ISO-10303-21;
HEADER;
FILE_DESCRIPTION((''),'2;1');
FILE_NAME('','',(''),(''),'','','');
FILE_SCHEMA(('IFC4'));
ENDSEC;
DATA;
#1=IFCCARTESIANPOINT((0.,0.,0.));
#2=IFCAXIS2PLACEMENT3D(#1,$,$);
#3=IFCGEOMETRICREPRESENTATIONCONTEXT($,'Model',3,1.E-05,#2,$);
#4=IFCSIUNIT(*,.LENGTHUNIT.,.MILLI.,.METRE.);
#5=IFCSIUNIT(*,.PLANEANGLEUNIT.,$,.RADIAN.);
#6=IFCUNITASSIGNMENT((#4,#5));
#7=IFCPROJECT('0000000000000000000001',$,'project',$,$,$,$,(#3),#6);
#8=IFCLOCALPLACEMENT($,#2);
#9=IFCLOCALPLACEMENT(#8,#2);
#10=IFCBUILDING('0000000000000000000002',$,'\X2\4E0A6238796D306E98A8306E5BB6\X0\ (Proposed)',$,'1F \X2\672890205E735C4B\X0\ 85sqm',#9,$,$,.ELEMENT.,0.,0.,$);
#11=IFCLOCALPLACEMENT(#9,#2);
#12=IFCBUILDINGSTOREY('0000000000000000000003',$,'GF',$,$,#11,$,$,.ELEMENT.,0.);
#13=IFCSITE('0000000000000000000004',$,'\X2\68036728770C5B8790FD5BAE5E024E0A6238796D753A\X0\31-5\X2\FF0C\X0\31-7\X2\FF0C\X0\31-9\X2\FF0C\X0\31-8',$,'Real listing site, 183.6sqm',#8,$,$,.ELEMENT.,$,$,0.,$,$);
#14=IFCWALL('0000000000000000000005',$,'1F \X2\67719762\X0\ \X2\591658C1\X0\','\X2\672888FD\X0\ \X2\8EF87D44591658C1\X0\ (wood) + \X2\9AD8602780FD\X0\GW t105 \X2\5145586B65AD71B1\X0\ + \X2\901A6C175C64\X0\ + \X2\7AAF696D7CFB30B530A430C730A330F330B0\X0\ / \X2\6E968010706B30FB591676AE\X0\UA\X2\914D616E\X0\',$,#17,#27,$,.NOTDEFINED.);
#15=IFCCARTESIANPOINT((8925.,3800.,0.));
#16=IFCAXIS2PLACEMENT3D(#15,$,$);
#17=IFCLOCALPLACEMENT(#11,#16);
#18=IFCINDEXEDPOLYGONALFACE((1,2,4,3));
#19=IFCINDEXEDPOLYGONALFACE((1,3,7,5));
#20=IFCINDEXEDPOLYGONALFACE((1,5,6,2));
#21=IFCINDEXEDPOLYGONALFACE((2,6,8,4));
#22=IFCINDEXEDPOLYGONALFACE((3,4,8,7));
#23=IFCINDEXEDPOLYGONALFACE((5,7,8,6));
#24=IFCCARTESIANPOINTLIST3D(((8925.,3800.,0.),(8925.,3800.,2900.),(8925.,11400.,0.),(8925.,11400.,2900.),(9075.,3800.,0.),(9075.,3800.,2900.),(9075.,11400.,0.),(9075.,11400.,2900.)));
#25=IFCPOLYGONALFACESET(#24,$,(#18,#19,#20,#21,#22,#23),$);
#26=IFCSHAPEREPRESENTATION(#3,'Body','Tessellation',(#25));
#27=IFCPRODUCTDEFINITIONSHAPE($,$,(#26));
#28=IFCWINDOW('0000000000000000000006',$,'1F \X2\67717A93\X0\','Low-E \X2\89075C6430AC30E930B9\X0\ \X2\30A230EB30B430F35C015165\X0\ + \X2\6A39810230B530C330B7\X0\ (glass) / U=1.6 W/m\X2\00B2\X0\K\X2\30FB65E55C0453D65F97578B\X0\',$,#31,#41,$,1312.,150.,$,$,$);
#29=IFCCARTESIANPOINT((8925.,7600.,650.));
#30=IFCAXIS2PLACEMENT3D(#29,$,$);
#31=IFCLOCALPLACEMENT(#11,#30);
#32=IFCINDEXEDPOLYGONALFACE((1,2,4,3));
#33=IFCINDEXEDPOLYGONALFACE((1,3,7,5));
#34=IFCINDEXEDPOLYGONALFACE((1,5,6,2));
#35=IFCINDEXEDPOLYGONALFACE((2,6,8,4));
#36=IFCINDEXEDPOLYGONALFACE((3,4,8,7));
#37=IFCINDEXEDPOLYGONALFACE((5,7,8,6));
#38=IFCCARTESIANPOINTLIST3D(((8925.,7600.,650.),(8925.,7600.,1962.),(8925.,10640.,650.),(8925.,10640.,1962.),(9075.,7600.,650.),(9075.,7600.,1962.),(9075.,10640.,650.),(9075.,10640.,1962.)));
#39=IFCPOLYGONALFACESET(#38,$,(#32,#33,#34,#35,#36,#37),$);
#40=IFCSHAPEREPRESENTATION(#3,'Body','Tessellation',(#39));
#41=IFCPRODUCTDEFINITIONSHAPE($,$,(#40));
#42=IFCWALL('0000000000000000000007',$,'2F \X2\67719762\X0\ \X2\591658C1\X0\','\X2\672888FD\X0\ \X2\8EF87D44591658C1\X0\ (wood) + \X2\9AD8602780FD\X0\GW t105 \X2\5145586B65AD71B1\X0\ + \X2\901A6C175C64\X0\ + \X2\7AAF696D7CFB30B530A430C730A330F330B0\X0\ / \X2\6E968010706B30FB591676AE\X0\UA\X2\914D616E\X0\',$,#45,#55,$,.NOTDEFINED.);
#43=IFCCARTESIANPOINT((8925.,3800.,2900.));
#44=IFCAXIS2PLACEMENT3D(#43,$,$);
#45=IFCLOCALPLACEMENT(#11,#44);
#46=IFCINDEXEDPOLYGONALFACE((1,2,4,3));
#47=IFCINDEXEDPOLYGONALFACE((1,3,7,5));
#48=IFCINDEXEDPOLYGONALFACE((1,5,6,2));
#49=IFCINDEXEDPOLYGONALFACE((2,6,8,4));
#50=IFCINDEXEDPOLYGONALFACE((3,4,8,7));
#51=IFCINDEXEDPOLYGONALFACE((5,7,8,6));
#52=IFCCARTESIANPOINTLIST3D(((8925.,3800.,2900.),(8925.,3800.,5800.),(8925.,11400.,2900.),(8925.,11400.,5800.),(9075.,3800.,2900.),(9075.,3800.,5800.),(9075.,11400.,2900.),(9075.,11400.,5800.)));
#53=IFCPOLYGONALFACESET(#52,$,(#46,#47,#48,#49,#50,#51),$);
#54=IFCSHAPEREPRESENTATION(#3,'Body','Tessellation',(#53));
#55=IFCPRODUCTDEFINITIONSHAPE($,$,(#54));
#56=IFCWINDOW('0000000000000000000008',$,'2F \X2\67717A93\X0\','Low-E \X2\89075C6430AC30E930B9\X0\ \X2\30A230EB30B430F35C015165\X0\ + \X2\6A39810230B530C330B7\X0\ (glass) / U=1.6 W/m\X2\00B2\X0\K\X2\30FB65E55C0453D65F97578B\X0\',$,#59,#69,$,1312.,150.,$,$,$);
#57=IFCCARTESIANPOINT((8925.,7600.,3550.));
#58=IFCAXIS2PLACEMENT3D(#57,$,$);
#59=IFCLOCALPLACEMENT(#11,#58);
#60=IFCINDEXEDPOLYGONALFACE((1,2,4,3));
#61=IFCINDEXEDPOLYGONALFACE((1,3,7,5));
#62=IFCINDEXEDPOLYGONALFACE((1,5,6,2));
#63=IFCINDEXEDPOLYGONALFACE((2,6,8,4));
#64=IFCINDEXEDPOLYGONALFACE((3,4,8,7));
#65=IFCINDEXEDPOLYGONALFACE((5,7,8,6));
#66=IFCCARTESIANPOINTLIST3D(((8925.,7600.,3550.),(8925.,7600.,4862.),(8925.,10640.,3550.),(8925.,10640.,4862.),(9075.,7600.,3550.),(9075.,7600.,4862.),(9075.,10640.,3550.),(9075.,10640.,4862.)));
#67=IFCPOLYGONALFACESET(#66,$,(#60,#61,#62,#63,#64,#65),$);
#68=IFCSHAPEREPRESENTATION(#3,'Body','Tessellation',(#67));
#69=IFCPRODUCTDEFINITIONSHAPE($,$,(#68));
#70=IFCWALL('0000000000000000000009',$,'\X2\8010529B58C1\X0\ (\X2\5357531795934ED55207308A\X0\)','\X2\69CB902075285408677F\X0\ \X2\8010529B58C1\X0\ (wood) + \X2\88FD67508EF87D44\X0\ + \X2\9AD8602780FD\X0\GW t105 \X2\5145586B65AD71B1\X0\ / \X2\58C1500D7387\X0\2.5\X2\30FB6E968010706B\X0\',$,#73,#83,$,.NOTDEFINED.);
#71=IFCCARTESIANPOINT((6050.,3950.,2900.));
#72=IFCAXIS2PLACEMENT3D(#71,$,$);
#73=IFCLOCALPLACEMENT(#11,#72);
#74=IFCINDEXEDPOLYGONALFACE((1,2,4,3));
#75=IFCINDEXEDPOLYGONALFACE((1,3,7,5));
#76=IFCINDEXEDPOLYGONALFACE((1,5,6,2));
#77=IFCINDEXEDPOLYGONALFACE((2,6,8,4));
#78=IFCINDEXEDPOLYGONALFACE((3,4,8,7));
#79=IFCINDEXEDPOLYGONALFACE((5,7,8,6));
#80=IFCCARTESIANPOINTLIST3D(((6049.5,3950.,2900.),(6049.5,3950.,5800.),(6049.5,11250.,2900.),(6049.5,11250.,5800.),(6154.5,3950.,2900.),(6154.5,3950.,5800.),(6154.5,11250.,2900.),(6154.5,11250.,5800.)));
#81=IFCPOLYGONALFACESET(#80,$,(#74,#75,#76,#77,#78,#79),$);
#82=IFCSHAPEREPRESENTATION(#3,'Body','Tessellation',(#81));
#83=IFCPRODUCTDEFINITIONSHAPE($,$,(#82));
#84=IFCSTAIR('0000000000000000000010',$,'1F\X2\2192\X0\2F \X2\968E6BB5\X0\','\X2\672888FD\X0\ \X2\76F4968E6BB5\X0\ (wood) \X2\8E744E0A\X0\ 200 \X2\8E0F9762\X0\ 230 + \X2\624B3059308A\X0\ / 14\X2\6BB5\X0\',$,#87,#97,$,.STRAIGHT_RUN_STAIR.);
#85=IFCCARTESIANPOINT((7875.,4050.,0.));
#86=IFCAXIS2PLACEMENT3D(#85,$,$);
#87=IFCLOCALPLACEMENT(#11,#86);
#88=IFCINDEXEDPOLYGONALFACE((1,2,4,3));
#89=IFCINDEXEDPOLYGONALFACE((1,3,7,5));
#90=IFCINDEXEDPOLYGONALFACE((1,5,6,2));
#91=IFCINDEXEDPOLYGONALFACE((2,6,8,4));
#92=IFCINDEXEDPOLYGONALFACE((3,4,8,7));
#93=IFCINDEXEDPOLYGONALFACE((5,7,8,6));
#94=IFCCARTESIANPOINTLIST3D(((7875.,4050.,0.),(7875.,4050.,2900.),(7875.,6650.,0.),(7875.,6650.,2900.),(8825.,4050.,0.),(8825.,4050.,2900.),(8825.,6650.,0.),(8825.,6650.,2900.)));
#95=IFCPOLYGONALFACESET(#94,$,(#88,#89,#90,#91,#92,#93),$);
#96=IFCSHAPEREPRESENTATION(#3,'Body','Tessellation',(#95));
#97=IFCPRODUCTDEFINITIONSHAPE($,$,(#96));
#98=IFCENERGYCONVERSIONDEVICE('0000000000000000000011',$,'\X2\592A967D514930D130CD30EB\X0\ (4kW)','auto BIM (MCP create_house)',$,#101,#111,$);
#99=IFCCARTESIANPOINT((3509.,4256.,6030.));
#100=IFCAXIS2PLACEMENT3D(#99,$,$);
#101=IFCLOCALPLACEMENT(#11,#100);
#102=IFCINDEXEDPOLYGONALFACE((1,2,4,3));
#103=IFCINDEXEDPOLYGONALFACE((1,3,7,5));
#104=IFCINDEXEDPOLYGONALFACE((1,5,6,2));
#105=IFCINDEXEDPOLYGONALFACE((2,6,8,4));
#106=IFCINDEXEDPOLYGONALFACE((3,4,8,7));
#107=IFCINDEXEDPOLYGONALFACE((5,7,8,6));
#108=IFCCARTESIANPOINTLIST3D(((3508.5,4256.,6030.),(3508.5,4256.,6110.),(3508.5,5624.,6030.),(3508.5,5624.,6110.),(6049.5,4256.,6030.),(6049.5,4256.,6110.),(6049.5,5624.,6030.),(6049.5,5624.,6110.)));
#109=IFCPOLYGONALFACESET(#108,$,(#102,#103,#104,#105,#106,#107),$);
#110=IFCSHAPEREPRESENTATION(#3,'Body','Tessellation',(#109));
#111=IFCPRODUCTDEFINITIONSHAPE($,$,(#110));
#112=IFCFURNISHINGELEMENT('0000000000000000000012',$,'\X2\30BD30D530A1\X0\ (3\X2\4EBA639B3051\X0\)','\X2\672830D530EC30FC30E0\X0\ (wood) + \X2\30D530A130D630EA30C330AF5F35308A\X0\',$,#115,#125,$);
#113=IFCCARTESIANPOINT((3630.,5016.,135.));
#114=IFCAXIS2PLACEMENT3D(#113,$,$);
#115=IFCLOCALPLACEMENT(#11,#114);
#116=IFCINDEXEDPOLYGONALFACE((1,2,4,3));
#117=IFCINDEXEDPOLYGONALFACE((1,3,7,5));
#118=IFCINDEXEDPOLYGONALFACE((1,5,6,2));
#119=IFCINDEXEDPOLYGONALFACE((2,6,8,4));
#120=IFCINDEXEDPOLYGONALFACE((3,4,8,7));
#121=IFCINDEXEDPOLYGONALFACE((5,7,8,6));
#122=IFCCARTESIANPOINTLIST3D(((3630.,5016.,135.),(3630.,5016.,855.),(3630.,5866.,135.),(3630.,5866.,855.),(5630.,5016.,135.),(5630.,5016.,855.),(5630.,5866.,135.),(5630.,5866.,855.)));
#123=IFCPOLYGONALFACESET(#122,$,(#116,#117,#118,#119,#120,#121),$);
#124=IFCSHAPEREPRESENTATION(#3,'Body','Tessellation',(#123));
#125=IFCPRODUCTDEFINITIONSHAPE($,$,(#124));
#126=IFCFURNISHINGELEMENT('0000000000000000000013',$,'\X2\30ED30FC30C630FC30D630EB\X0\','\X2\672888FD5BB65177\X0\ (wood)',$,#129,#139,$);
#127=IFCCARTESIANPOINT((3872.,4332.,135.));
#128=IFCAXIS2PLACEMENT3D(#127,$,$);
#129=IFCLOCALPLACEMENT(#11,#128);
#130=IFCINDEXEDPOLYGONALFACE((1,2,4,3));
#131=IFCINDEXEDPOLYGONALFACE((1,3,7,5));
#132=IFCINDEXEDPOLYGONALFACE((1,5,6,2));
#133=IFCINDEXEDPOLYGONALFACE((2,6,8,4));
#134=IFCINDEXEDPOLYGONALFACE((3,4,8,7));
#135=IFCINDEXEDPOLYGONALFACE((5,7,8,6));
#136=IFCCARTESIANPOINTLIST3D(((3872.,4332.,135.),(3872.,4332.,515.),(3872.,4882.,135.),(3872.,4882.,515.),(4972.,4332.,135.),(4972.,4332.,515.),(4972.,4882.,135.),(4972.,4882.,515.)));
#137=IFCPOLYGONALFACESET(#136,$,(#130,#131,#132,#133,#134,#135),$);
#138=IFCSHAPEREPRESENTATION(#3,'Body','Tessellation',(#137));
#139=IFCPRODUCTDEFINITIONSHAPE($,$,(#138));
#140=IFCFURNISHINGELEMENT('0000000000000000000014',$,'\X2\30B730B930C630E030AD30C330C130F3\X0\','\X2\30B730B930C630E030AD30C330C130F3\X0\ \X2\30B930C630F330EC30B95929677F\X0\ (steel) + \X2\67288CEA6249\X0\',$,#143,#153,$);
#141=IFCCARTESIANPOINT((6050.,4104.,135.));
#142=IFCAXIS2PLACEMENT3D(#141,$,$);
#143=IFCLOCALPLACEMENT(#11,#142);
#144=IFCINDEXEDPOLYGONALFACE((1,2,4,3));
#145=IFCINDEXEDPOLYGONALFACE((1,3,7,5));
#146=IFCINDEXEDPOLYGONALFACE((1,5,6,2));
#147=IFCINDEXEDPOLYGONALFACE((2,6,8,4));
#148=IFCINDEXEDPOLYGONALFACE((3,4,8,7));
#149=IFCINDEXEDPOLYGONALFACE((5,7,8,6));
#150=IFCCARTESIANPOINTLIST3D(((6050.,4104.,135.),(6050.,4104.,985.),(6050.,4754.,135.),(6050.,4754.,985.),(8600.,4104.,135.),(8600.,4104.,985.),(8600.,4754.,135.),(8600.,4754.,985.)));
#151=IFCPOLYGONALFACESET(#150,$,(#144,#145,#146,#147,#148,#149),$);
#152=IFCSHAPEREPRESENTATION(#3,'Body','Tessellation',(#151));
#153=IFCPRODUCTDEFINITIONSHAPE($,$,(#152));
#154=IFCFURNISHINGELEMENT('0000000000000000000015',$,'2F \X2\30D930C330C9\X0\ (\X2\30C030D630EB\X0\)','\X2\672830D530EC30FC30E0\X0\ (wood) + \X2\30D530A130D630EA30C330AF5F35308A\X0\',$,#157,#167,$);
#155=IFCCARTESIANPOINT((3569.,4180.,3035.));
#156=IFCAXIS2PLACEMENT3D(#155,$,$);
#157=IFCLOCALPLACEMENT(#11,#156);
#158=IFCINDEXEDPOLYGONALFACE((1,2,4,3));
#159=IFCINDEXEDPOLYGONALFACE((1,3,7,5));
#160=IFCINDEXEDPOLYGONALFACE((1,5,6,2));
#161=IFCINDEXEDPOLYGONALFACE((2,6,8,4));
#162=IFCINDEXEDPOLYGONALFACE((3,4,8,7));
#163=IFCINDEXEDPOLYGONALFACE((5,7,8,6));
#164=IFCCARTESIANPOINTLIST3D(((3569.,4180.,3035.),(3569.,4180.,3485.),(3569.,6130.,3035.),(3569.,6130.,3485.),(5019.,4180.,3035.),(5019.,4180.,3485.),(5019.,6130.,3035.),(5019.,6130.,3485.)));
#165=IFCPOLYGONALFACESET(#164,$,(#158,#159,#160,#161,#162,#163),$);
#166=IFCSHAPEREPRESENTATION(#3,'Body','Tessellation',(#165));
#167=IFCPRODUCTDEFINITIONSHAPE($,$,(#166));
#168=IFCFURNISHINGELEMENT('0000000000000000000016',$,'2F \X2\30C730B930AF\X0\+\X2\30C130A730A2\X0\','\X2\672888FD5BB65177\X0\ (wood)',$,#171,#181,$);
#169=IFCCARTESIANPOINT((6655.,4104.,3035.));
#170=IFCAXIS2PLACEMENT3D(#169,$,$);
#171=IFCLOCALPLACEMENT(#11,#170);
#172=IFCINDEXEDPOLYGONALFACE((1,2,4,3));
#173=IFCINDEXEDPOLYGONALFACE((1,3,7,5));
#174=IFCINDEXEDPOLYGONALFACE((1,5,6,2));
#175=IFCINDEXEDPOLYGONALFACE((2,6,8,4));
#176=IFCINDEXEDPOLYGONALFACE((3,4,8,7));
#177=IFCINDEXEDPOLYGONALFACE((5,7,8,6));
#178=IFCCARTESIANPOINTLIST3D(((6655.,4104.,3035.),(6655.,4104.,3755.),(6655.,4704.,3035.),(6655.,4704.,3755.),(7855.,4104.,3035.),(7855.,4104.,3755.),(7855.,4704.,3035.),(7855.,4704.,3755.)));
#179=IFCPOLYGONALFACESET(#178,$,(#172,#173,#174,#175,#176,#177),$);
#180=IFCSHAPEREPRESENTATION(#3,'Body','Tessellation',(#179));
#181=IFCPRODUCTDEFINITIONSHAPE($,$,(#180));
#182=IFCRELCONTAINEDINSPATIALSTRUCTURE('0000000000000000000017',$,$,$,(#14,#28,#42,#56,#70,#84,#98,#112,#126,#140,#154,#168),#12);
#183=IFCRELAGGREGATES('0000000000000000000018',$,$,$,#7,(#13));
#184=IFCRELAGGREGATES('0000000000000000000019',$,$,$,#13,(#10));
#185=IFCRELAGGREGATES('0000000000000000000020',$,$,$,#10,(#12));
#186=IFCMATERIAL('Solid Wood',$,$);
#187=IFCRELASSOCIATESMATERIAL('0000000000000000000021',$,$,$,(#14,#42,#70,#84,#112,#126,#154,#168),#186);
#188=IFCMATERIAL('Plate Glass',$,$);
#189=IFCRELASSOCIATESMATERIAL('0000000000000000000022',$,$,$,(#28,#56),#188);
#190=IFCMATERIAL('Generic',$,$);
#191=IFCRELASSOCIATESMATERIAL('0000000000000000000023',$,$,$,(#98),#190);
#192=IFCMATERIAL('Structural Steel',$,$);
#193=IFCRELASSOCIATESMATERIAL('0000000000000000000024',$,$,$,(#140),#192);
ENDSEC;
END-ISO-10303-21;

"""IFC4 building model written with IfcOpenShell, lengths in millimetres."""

from ifc_helpers import new_model, si_unit, frame, frame_2d, origin, place, context, project, spatial, rectangle, extrude, material, element, fill, save


model = new_model("IFC4")

# Units and contexts
model_context = context("Model", 3, precision=1e-05, world=origin())
ifc_project = project(units=[si_unit("LENGTHUNIT", "METRE", prefix="MILLI"), si_unit("PLANEANGLEUNIT", "RADIAN")], contexts=[model_context])

# Site, building, storey
site_placement = place(None, origin())
site = spatial("IfcSite", under=ifc_project, at=site_placement, Name="栃木県宇都宮市上戸祭町31-5，31-7，31-9，31-8", ObjectType="Real listing site, 183.6sqm", CompositionType="ELEMENT", RefElevation=0.0)
building_placement = place(site_placement, origin())
building = spatial("IfcBuilding", under=site, at=building_placement, Name="上戸祭の風の家 (Proposed)", ObjectType="1F 木造平屋 85sqm", CompositionType="ELEMENT", ElevationOfRefHeight=0.0, ElevationOfTerrain=0.0)
storey_placement = place(building_placement, origin())
storey = spatial("IfcBuildingStorey", under=building, at=storey_placement, Name="GF", CompositionType="ELEMENT", Elevation=0.0)

# Wall, opening, window
ifc_material_1 = material(Name="Solid Wood")
wall_1_placement = place(storey_placement, frame((8925.0, 3800.0, 0.0)))
wall_1 = element("IfcWall", 1, at=wall_1_placement, inside=storey, material=ifc_material_1, Name="1F 東面 外壁", Description="木製 軸組外壁 (wood) + 高性能GW t105 充填断熱 + 通気層 + 窯業系サイディング / 準耐火・外皮UA配慮", PredefinedType="NOTDEFINED", context=model_context, shape_type="SweptSolid", body=[
    extrude(rectangle(XDim=150.0, YDim=7600.0, at=frame_2d((75.0, 3800.0))), frame((8925.0, 3800.0, 0.0)), (0.0, 0.0, 1.0), 2900.0),
])
opening_1_placement = place(storey_placement, frame((8925.0, 7600.0, 650.0)))
opening_1 = element("IfcOpeningElement", 2, at=opening_1_placement, cuts=wall_1, PredefinedType="NOTDEFINED", context=model_context, shape_type="SweptSolid", body=[
    extrude(rectangle(XDim=150.0, YDim=3040.0, at=frame_2d((75.0, 1520.0))), frame((8925.0, 7600.0, 650.0)), (0.0, 0.0, 1.0), 1312.0),
])
ifc_material_2 = material(Name="Plate Glass")
window_1_placement = place(storey_placement, frame((8925.0, 7600.0, 650.0)))
window_1 = element("IfcWindow", 3, at=window_1_placement, inside=storey, material=ifc_material_2, Name="1F 東窓", Description="Low-E 複層ガラス アルゴン封入 + 樹脂サッシ (glass) / U=1.6 W/m²K・日射取得型", OverallHeight=1312.0, OverallWidth=150.0, context=model_context, shape_type="SweptSolid", body=[
    extrude(rectangle(XDim=150.0, YDim=3040.0, at=frame_2d((75.0, 1520.0))), frame((8925.0, 7600.0, 650.0)), (0.0, 0.0, 1.0), 1312.0),
])
fill(opening_1, window_1)

# Wall, opening, window
wall_2_placement = place(storey_placement, frame((8925.0, 3800.0, 2900.0)))
wall_2 = element("IfcWall", 4, at=wall_2_placement, inside=storey, material=ifc_material_1, Name="2F 東面 外壁", Description="木製 軸組外壁 (wood) + 高性能GW t105 充填断熱 + 通気層 + 窯業系サイディング / 準耐火・外皮UA配慮", PredefinedType="NOTDEFINED", context=model_context, shape_type="SweptSolid", body=[
    extrude(rectangle(XDim=150.0, YDim=7600.0, at=frame_2d((75.0, 3800.0))), frame((8925.0, 3800.0, 2900.0)), (0.0, 0.0, 1.0), 2900.0),
])
opening_2_placement = place(storey_placement, frame((8925.0, 7600.0, 3550.0)))
opening_2 = element("IfcOpeningElement", 5, at=opening_2_placement, cuts=wall_2, PredefinedType="NOTDEFINED", context=model_context, shape_type="SweptSolid", body=[
    extrude(rectangle(XDim=150.0, YDim=3040.0, at=frame_2d((75.0, 1520.0))), frame((8925.0, 7600.0, 3550.0)), (0.0, 0.0, 1.0), 1312.0),
])
window_2_placement = place(storey_placement, frame((8925.0, 7600.0, 3550.0)))
window_2 = element("IfcWindow", 6, at=window_2_placement, inside=storey, material=ifc_material_2, Name="2F 東窓", Description="Low-E 複層ガラス アルゴン封入 + 樹脂サッシ (glass) / U=1.6 W/m²K・日射取得型", OverallHeight=1312.0, OverallWidth=150.0, context=model_context, shape_type="SweptSolid", body=[
    extrude(rectangle(XDim=150.0, YDim=3040.0, at=frame_2d((75.0, 1520.0))), frame((8925.0, 7600.0, 3550.0)), (0.0, 0.0, 1.0), 1312.0),
])
fill(opening_2, window_2)

# Wall
wall_3_placement = place(storey_placement, frame((6050.0, 3950.0, 2900.0)))
element("IfcWall", 7, at=wall_3_placement, inside=storey, material=ifc_material_1, Name="耐力壁 (南北間仕切り)", Description="構造用合板 耐力壁 (wood) + 製材軸組 + 高性能GW t105 充填断熱 / 壁倍率2.5・準耐火", PredefinedType="NOTDEFINED", context=model_context, shape_type="SweptSolid", body=[
    extrude(rectangle(XDim=105.0, YDim=7300.0, at=frame_2d((52.0, 3650.0))), frame((6050.0, 3950.0, 2900.0)), (0.0, 0.0, 1.0), 2900.0),
])

# Stair
stair_placement = place(storey_placement, frame((7875.0, 4050.0, 0.0)))
element("IfcStair", 8, at=stair_placement, inside=storey, material=ifc_material_1, Name="1F→2F 階段", Description="木製 直階段 (wood) 蹴上 200 踏面 230 + 手すり / 14段", PredefinedType="STRAIGHT_RUN_STAIR", context=model_context, shape_type="SweptSolid", body=[
    extrude(rectangle(XDim=950.0, YDim=2600.0, at=frame_2d((475.0, 1300.0))), frame((7875.0, 4050.0, 0.0)), (0.0, 0.0, 1.0), 2900.0),
])

# Energy conversion device
ifc_material_3 = material(Name="Generic")
energy_conversion_device_placement = place(storey_placement, frame((3509.0, 4256.0, 6030.0)))
element("IfcEnergyConversionDevice", 9, at=energy_conversion_device_placement, inside=storey, material=ifc_material_3, Name="太陽光パネル (4kW)", Description="auto BIM (MCP create_house)", context=model_context, shape_type="SweptSolid", body=[
    extrude(rectangle(XDim=2541.0, YDim=1368.0, at=frame_2d((1270.0, 684.0))), frame((3509.0, 4256.0, 6030.0)), (0.0, 0.0, 1.0), 80.0),
])

# Furnishing elements
furnishing_1_placement = place(storey_placement, frame((3630.0, 5016.0, 135.0)))
element("IfcFurnishingElement", 10, at=furnishing_1_placement, inside=storey, material=ifc_material_1, Name="ソファ (3人掛け)", Description="木フレーム (wood) + ファブリック張り", context=model_context, shape_type="SweptSolid", body=[
    extrude(rectangle(XDim=2000.0, YDim=850.0, at=frame_2d((1000.0, 425.0))), frame((3630.0, 5016.0, 135.0)), (0.0, 0.0, 1.0), 720.0),
])
furnishing_2_placement = place(storey_placement, frame((3872.0, 4332.0, 135.0)))
element("IfcFurnishingElement", 11, at=furnishing_2_placement, inside=storey, material=ifc_material_1, Name="ローテーブル", Description="木製家具 (wood)", context=model_context, shape_type="SweptSolid", body=[
    extrude(rectangle(XDim=1100.0, YDim=550.0, at=frame_2d((550.0, 275.0))), frame((3872.0, 4332.0, 135.0)), (0.0, 0.0, 1.0), 380.0),
])
ifc_material_4 = material(Name="Structural Steel")
furnishing_3_placement = place(storey_placement, frame((6050.0, 4104.0, 135.0)))
element("IfcFurnishingElement", 12, at=furnishing_3_placement, inside=storey, material=ifc_material_4, Name="システムキッチン", Description="システムキッチン ステンレス天板 (steel) + 木質扉", context=model_context, shape_type="SweptSolid", body=[
    extrude(rectangle(XDim=2550.0, YDim=650.0, at=frame_2d((1275.0, 325.0))), frame((6050.0, 4104.0, 135.0)), (0.0, 0.0, 1.0), 850.0),
])
furnishing_4_placement = place(storey_placement, frame((3569.0, 4180.0, 3035.0)))
element("IfcFurnishingElement", 13, at=furnishing_4_placement, inside=storey, material=ifc_material_1, Name="2F ベッド (ダブル)", Description="木フレーム (wood) + ファブリック張り", context=model_context, shape_type="SweptSolid", body=[
    extrude(rectangle(XDim=1450.0, YDim=1950.0, at=frame_2d((725.0, 975.0))), frame((3569.0, 4180.0, 3035.0)), (0.0, 0.0, 1.0), 450.0),
])
furnishing_5_placement = place(storey_placement, frame((6655.0, 4104.0, 3035.0)))
element("IfcFurnishingElement", 14, at=furnishing_5_placement, inside=storey, material=ifc_material_1, Name="2F デスク+チェア", Description="木製家具 (wood)", context=model_context, shape_type="SweptSolid", body=[
    extrude(rectangle(XDim=1200.0, YDim=600.0, at=frame_2d((600.0, 300.0))), frame((6655.0, 4104.0, 3035.0)), (0.0, 0.0, 1.0), 720.0),
])

save(model, "model.ifc")
